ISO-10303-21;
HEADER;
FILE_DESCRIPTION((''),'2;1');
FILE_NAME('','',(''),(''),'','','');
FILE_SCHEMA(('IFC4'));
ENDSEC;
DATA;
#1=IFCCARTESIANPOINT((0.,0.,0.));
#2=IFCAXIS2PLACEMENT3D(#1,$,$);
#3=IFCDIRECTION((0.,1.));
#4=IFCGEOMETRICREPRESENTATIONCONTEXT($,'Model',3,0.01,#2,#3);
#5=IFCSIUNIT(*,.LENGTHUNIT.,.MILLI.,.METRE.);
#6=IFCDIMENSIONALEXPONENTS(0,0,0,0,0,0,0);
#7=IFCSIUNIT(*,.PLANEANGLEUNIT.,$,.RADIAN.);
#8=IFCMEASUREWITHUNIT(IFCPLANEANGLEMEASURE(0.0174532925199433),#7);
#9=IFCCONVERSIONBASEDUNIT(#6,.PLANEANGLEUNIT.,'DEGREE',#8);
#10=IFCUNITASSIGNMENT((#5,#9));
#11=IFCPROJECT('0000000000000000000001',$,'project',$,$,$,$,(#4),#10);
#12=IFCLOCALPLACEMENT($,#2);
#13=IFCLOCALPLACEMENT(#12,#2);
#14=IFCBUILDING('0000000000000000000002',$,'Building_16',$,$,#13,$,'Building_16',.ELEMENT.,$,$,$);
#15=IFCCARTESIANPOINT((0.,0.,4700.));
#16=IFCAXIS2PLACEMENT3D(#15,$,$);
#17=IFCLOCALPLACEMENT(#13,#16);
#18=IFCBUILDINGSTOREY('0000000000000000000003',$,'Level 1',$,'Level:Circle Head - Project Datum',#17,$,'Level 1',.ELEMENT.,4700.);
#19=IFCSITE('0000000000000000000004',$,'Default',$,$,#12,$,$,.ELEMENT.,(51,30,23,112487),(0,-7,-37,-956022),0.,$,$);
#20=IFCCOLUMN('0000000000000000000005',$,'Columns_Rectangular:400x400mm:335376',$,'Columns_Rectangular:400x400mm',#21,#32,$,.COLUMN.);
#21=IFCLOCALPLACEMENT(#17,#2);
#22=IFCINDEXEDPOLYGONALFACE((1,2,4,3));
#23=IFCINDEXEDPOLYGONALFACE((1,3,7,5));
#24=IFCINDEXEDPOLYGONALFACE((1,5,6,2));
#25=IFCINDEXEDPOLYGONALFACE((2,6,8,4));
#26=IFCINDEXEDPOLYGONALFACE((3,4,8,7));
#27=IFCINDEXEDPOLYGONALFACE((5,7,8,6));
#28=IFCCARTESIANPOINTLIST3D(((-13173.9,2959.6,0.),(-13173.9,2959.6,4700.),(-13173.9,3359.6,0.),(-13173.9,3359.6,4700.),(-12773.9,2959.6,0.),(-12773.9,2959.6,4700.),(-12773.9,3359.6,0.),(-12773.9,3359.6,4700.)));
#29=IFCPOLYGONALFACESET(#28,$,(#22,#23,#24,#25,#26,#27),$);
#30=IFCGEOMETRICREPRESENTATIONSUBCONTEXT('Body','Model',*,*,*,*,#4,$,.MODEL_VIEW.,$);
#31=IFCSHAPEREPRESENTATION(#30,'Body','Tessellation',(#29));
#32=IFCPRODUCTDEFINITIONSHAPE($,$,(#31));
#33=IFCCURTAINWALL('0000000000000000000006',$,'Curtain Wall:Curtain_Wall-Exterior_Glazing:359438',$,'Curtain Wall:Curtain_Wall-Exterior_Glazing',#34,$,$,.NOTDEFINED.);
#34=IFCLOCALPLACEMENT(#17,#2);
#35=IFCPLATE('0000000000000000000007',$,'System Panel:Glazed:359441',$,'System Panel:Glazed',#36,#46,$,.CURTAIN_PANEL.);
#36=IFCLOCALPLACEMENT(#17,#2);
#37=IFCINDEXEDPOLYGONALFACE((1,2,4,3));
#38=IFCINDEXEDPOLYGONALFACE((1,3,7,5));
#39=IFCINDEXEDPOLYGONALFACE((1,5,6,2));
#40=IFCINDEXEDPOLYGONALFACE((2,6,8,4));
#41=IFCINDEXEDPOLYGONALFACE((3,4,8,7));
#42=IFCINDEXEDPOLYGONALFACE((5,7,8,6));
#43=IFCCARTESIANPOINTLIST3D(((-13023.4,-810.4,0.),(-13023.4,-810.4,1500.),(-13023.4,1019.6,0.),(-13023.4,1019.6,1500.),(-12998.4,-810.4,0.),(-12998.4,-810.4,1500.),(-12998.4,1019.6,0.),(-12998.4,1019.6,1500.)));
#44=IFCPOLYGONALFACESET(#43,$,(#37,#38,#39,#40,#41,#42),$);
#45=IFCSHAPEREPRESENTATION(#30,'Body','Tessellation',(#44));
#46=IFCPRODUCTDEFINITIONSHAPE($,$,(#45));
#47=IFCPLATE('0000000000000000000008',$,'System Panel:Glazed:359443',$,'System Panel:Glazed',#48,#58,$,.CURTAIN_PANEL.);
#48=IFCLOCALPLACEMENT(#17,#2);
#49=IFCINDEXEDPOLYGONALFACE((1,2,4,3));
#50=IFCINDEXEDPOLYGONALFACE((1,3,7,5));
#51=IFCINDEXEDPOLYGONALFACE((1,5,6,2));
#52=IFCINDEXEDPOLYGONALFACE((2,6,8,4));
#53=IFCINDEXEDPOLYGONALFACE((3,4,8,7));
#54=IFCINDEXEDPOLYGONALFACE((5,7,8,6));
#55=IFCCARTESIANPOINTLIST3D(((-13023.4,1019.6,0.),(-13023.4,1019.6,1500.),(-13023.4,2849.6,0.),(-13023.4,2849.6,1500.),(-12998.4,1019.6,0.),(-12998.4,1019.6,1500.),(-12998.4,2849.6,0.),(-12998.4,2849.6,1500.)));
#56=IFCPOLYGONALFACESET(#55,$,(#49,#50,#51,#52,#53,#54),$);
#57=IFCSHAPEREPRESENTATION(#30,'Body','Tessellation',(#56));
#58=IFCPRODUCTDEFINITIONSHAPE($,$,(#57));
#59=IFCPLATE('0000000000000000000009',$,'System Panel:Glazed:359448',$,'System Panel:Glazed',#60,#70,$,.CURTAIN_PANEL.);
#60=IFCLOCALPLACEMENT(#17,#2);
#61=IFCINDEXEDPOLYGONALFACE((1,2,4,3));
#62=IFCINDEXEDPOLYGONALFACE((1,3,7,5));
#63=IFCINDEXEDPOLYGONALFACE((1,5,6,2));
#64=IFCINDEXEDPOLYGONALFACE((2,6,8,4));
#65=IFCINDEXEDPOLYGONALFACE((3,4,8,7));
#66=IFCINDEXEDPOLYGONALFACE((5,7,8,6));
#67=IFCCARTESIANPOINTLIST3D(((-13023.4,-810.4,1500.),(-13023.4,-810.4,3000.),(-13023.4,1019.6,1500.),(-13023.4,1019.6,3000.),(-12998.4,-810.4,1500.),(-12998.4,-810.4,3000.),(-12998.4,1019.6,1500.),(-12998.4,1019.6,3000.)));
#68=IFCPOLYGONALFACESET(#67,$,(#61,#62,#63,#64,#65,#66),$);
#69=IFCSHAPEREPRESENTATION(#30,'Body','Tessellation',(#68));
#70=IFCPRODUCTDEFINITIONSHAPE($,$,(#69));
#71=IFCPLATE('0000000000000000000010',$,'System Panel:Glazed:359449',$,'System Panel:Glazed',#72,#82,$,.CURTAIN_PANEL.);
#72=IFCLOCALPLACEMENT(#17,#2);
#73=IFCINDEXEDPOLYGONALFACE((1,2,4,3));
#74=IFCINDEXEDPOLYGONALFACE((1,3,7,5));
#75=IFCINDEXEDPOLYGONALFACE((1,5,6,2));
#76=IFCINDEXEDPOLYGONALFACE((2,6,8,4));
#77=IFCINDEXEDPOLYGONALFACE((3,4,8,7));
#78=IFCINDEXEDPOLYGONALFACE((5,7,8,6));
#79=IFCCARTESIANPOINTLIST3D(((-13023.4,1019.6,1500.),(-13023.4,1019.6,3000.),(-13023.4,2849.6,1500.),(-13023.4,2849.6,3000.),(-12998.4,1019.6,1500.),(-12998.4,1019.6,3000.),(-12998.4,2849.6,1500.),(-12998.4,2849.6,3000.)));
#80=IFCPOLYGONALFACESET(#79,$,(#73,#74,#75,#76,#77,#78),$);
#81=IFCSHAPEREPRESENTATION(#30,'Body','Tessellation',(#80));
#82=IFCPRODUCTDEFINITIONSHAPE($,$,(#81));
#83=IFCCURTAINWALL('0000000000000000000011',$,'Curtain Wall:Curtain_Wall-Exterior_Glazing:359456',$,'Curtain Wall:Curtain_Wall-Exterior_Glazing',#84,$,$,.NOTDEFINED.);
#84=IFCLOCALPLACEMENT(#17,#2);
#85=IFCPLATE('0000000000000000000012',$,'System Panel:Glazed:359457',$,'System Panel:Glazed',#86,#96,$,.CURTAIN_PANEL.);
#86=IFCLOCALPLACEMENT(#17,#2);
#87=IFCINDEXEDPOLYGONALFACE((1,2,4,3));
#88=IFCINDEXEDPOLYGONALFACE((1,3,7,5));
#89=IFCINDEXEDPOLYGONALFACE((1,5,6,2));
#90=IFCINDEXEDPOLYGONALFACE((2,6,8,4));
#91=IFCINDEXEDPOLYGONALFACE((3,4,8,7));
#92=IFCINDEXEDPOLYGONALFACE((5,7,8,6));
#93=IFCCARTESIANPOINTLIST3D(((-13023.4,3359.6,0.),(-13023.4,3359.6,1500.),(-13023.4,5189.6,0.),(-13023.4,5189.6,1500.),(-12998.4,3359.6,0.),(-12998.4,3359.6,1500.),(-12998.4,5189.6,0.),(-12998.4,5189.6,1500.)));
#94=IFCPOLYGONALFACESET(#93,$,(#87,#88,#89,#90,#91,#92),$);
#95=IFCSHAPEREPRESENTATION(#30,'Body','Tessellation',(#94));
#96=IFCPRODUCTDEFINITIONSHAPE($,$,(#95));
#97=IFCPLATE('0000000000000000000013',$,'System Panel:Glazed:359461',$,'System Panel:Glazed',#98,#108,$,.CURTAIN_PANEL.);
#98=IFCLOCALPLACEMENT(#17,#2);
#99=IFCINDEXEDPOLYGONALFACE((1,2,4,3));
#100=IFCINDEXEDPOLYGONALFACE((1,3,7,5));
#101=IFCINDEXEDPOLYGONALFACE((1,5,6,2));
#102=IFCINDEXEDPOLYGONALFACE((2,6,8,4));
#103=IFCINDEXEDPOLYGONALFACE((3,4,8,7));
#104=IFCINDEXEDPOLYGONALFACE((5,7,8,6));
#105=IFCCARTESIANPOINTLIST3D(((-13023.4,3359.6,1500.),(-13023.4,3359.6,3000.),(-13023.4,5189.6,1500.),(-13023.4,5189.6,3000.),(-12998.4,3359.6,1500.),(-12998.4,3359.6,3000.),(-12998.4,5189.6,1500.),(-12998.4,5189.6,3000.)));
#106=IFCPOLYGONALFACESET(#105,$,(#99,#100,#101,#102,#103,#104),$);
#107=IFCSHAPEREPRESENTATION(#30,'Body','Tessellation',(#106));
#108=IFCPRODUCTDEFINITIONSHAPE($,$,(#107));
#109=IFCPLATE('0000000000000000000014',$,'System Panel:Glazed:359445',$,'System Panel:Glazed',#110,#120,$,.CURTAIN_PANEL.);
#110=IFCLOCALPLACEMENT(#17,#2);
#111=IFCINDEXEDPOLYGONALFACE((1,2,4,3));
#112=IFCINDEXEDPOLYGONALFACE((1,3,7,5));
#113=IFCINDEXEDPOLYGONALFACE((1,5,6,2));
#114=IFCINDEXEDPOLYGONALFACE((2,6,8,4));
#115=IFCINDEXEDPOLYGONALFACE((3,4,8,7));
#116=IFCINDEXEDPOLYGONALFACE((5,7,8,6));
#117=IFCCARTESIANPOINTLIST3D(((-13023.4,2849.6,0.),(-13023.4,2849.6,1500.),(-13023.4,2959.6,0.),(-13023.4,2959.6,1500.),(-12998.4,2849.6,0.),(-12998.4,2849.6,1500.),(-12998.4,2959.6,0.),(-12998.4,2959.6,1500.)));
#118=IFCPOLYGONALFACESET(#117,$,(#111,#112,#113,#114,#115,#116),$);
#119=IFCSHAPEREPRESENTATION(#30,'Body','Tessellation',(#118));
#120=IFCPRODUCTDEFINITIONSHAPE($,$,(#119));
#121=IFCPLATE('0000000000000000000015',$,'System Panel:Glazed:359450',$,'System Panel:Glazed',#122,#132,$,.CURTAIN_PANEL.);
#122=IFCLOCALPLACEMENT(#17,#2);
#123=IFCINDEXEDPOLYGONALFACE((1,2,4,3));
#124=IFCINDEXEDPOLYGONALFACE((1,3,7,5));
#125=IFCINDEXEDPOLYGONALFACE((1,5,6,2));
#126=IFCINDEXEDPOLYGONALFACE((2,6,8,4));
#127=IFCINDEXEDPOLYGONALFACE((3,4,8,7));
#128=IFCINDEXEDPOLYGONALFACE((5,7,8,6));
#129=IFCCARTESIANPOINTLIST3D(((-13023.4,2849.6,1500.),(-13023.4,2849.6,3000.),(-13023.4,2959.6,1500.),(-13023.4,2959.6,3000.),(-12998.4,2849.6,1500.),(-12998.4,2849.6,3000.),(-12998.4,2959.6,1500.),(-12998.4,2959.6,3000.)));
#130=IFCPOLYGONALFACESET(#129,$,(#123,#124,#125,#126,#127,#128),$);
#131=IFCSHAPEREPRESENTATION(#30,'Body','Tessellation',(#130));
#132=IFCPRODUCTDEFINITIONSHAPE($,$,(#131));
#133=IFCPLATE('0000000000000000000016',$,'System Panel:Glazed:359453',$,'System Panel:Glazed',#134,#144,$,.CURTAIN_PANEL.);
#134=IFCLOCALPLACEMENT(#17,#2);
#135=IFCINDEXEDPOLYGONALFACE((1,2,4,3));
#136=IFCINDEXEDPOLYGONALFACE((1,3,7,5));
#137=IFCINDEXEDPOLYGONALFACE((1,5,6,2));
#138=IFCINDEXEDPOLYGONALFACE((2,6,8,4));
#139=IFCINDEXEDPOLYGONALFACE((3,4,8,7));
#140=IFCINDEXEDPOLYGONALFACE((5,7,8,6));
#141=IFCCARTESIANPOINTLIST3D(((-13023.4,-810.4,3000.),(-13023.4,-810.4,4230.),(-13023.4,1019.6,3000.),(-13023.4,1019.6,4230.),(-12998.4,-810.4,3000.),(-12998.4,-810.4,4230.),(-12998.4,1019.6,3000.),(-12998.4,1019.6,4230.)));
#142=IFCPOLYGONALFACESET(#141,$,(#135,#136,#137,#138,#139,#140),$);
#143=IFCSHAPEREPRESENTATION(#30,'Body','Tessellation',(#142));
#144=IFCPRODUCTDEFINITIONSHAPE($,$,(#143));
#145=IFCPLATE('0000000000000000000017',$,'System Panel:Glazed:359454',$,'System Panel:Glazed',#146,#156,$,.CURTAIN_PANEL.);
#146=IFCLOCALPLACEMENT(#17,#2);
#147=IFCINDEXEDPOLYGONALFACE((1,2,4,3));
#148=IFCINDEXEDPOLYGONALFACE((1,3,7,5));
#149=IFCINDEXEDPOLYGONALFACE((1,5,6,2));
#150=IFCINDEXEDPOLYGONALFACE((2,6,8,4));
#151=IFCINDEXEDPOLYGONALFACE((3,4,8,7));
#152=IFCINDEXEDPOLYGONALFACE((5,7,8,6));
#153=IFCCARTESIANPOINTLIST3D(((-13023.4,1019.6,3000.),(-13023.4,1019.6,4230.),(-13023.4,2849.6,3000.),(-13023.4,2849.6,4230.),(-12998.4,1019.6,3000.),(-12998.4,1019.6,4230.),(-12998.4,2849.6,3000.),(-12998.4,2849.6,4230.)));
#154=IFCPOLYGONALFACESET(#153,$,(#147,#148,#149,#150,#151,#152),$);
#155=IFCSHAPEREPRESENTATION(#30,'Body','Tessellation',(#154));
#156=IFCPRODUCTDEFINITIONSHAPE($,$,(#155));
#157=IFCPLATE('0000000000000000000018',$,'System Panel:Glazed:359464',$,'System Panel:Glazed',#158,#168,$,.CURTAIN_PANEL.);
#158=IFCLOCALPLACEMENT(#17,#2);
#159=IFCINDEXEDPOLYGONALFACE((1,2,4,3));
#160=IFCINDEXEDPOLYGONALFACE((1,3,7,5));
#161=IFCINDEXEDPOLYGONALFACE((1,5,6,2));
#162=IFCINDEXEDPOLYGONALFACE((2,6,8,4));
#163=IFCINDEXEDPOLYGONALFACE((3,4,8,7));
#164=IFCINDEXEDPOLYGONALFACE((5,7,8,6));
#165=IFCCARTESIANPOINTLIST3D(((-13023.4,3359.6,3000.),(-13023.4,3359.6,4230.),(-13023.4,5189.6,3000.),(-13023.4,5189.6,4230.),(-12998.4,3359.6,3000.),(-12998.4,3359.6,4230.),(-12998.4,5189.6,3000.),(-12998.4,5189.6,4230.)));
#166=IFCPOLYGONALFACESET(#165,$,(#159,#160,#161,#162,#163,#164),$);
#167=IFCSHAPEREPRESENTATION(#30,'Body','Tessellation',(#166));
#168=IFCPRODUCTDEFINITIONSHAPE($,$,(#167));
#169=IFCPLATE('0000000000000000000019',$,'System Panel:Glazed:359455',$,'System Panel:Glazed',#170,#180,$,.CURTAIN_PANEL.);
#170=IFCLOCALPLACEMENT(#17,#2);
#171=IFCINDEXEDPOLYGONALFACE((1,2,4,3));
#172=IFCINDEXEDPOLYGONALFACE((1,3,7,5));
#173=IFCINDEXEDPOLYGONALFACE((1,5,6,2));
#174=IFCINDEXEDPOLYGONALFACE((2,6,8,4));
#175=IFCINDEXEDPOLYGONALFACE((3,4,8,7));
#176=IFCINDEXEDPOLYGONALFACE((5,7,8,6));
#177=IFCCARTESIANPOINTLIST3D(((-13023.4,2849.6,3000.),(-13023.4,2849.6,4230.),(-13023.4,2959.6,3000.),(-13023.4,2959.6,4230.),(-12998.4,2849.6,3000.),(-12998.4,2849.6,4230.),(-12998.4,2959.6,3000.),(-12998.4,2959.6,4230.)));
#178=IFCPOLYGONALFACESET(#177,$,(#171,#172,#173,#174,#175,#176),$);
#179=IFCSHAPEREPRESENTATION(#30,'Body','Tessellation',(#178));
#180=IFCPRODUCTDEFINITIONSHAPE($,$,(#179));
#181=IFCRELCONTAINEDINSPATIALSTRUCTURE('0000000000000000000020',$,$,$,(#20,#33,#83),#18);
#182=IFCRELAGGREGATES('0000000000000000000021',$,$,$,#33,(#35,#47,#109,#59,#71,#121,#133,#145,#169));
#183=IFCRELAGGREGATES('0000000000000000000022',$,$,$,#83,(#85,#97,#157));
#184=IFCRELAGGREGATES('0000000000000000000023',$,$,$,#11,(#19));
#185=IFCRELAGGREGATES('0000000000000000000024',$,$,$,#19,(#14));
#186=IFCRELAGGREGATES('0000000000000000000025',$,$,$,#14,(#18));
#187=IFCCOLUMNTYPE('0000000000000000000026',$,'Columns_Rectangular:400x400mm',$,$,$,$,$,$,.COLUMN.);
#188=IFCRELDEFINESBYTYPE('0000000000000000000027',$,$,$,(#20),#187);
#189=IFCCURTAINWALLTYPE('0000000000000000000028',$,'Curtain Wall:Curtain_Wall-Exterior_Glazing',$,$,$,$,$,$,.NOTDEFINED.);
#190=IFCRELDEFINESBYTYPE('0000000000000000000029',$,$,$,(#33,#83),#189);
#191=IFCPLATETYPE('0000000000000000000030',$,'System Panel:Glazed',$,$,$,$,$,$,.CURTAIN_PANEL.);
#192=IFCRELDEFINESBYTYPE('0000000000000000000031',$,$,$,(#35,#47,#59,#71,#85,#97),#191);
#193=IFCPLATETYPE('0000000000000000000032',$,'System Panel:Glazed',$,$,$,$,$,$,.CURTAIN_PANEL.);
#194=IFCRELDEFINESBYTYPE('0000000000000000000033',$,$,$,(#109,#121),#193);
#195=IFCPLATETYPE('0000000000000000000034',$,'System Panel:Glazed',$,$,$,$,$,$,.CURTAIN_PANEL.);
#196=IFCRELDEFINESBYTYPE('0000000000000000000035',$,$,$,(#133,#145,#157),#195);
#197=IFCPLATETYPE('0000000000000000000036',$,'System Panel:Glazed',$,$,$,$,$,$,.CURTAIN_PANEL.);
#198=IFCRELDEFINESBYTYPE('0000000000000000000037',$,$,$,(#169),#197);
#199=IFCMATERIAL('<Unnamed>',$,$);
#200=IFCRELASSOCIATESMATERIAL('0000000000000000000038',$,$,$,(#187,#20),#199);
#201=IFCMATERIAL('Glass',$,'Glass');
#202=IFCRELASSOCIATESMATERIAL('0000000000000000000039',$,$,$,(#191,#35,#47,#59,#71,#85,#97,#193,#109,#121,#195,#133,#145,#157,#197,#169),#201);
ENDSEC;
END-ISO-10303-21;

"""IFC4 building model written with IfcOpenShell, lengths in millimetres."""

from ifc_helpers import new_model, entity, si_unit, converted_unit, direction, frame, origin, place, context, subcontext, project, spatial, indexed_curve, outline, extrude, source, transform, mapped, material, type_object, type_shapes, element, aggregate, save


model = new_model("IFC4")

# Units and contexts
model_context = context("Model", 3, precision=0.01, world=origin(), true_north=direction((0.0, 1.0)))
body_context = subcontext(model_context, "Body", "Model", "MODEL_VIEW")
ifc_project = project(units=[si_unit("LENGTHUNIT", "METRE", prefix="MILLI"), converted_unit("PLANEANGLEUNIT", "DEGREE", entity("IfcPlaneAngleMeasure", 0.0174532925199433), si_unit("PLANEANGLEUNIT", "RADIAN"), dimensions=[0, 0, 0, 0, 0, 0, 0])], contexts=[model_context])

# Site, building, storey
site_placement = place(None, origin())
site = spatial("IfcSite", under=ifc_project, at=site_placement, Name="Default", CompositionType="ELEMENT", RefLatitude=(51, 30, 23, 112487), RefLongitude=(0, -7, -37, -956022), RefElevation=0.0)
building_placement = place(site_placement, origin())
building = spatial("IfcBuilding", under=site, at=building_placement, Name="Building_16", LongName="Building_16", CompositionType="ELEMENT")
storey_placement = place(building_placement, frame((0.0, 0.0, 4700.0)))
storey = spatial("IfcBuildingStorey", under=building, at=storey_placement, Name="Level 1", ObjectType="Level:Circle Head - Project Datum", LongName="Level 1", CompositionType="ELEMENT", Elevation=4700.0)

# Column
ifc_material_1 = material(Name="<Unnamed>")
column_type_1 = type_object("IfcColumnType", Name="Columns_Rectangular:400x400mm", PredefinedType="COLUMN", material=ifc_material_1)
shared_shape_1 = source(origin(), body_context, "Body", "SweptSolid", [
    extrude(outline(indexed_curve([(-200.0, -200.0), (200.0, -200.0), (200.0, 200.0), (-200.0, 200.0), (-200.0, -200.0)], self_intersect=False)), frame((0.0, 0.0, 4700.0), z_axis=(0.0, 0.0, 1.0), x_axis=(-1.0, 0.0, 0.0)), (0.0, 0.0, 1.0), 4700.0),
])
type_shapes(column_type_1, [shared_shape_1])
column_1_placement = place(storey_placement, frame((-12973.9, 3159.6, -4700.0)))
element("IfcColumn", 1, at=column_1_placement, inside=storey, type_object=column_type_1, material=ifc_material_1, Name="Columns_Rectangular:400x400mm:335376", ObjectType="Columns_Rectangular:400x400mm", PredefinedType="COLUMN", context=body_context, shape_type="MappedRepresentation", body=[
    mapped(shared_shape_1, transform((0.0, 0.0, 0.0), scale=1.0)),
])

# Curtain walls, plates
curtain_wall_type = type_object("IfcCurtainWallType", Name="Curtain Wall:Curtain_Wall-Exterior_Glazing", PredefinedType="NOTDEFINED")
curtain_wall_1_placement = place(storey_placement, frame((0.0, 0.0, -4700.0)))
curtain_wall_1 = element("IfcCurtainWall", 2, at=curtain_wall_1_placement, inside=storey, type_object=curtain_wall_type, Name="Curtain Wall:Curtain_Wall-Exterior_Glazing:359438", ObjectType="Curtain Wall:Curtain_Wall-Exterior_Glazing", PredefinedType="NOTDEFINED")
ifc_material_2 = material(Name="Glass", Category="Glass")
plate_type_1 = type_object("IfcPlateType", Name="System Panel:Glazed", PredefinedType="CURTAIN_PANEL", material=ifc_material_2)
shared_shape_2 = source(origin(), body_context, "Body", "SweptSolid", [
    extrude(outline(indexed_curve([(-12.5, -915.0), (12.5, -915.0), (12.5, 915.0), (-12.5, 915.0), (-12.5, -915.0)], self_intersect=False)), frame((0.0, 37.0, 0.0), z_axis=(0.0, 0.0, 1.0), x_axis=(0.0, 1.0, 0.0)), (0.0, 0.0, 1.0), 1500.0),
])
type_shapes(plate_type_1, [shared_shape_2])
plate_1_placement = place(curtain_wall_1_placement, frame((-12973.9, 104.6, 4700.0), z_axis=(0.0, 0.0, 1.0), x_axis=(0.0, 1.0, 0.0)))
plate_1 = element("IfcPlate", 3, at=plate_1_placement, type_object=plate_type_1, material=ifc_material_2, Name="System Panel:Glazed:359441", ObjectType="System Panel:Glazed", PredefinedType="CURTAIN_PANEL", context=body_context, shape_type="MappedRepresentation", body=[
    mapped(shared_shape_2, transform((0.0, 0.0, 0.0), scale=1.0)),
])
plate_2_placement = place(curtain_wall_1_placement, frame((-12973.9, 1934.6, 4700.0), z_axis=(0.0, 0.0, 1.0), x_axis=(0.0, 1.0, 0.0)))
plate_2 = element("IfcPlate", 4, at=plate_2_placement, type_object=plate_type_1, material=ifc_material_2, Name="System Panel:Glazed:359443", ObjectType="System Panel:Glazed", PredefinedType="CURTAIN_PANEL", context=body_context, shape_type="MappedRepresentation", body=[
    mapped(shared_shape_2, transform((0.0, 0.0, 0.0), scale=1.0)),
])
plate_3_placement = place(curtain_wall_1_placement, frame((-12973.9, 104.6, 6200.0), z_axis=(0.0, 0.0, 1.0), x_axis=(0.0, 1.0, 0.0)))
plate_3 = element("IfcPlate", 5, at=plate_3_placement, type_object=plate_type_1, material=ifc_material_2, Name="System Panel:Glazed:359448", ObjectType="System Panel:Glazed", PredefinedType="CURTAIN_PANEL", context=body_context, shape_type="MappedRepresentation", body=[
    mapped(shared_shape_2, transform((0.0, 0.0, 0.0), scale=1.0)),
])
plate_4_placement = place(curtain_wall_1_placement, frame((-12973.9, 1934.6, 6200.0), z_axis=(0.0, 0.0, 1.0), x_axis=(0.0, 1.0, 0.0)))
plate_4 = element("IfcPlate", 6, at=plate_4_placement, type_object=plate_type_1, material=ifc_material_2, Name="System Panel:Glazed:359449", ObjectType="System Panel:Glazed", PredefinedType="CURTAIN_PANEL", context=body_context, shape_type="MappedRepresentation", body=[
    mapped(shared_shape_2, transform((0.0, 0.0, 0.0), scale=1.0)),
])
curtain_wall_2_placement = place(storey_placement, frame((0.0, 0.0, -4700.0)))
curtain_wall_2 = element("IfcCurtainWall", 7, at=curtain_wall_2_placement, inside=storey, type_object=curtain_wall_type, Name="Curtain Wall:Curtain_Wall-Exterior_Glazing:359456", ObjectType="Curtain Wall:Curtain_Wall-Exterior_Glazing", PredefinedType="NOTDEFINED")
plate_5_placement = place(curtain_wall_2_placement, frame((-12973.9, 4274.6, 4700.0), z_axis=(0.0, 0.0, 1.0), x_axis=(0.0, 1.0, 0.0)))
plate_5 = element("IfcPlate", 8, at=plate_5_placement, type_object=plate_type_1, material=ifc_material_2, Name="System Panel:Glazed:359457", ObjectType="System Panel:Glazed", PredefinedType="CURTAIN_PANEL", context=body_context, shape_type="MappedRepresentation", body=[
    mapped(shared_shape_2, transform((0.0, 0.0, 0.0), scale=1.0)),
])
plate_6_placement = place(curtain_wall_2_placement, frame((-12973.9, 4274.6, 6200.0), z_axis=(0.0, 0.0, 1.0), x_axis=(0.0, 1.0, 0.0)))
plate_6 = element("IfcPlate", 9, at=plate_6_placement, type_object=plate_type_1, material=ifc_material_2, Name="System Panel:Glazed:359461", ObjectType="System Panel:Glazed", PredefinedType="CURTAIN_PANEL", context=body_context, shape_type="MappedRepresentation", body=[
    mapped(shared_shape_2, transform((0.0, 0.0, 0.0), scale=1.0)),
])

# Plates
plate_type_2 = type_object("IfcPlateType", Name="System Panel:Glazed", PredefinedType="CURTAIN_PANEL", material=ifc_material_2)
shared_shape_3 = source(origin(), body_context, "Body", "SweptSolid", [
    extrude(outline(indexed_curve([(-12.5, -55.0), (12.5, -55.0), (12.5, 55.0), (-12.5, 55.0), (-12.5, -55.0)], self_intersect=False)), frame((0.0, 37.0, 0.0), z_axis=(0.0, 0.0, 1.0), x_axis=(0.0, 1.0, 0.0)), (0.0, 0.0, 1.0), 1500.0),
])
type_shapes(plate_type_2, [shared_shape_3])
plate_7_placement = place(curtain_wall_1_placement, frame((-12973.9, 2904.6, 4700.0), z_axis=(0.0, 0.0, 1.0), x_axis=(0.0, 1.0, 0.0)))
plate_7 = element("IfcPlate", 10, at=plate_7_placement, type_object=plate_type_2, material=ifc_material_2, Name="System Panel:Glazed:359445", ObjectType="System Panel:Glazed", PredefinedType="CURTAIN_PANEL", context=body_context, shape_type="MappedRepresentation", body=[
    mapped(shared_shape_3, transform((0.0, 0.0, 0.0), scale=1.0)),
])
plate_8_placement = place(curtain_wall_1_placement, frame((-12973.9, 2904.6, 6200.0), z_axis=(0.0, 0.0, 1.0), x_axis=(0.0, 1.0, 0.0)))
plate_8 = element("IfcPlate", 11, at=plate_8_placement, type_object=plate_type_2, material=ifc_material_2, Name="System Panel:Glazed:359450", ObjectType="System Panel:Glazed", PredefinedType="CURTAIN_PANEL", context=body_context, shape_type="MappedRepresentation", body=[
    mapped(shared_shape_3, transform((0.0, 0.0, 0.0), scale=1.0)),
])
plate_type_3 = type_object("IfcPlateType", Name="System Panel:Glazed", PredefinedType="CURTAIN_PANEL", material=ifc_material_2)
shared_shape_4 = source(origin(), body_context, "Body", "SweptSolid", [
    extrude(outline(indexed_curve([(-12.5, -915.0), (12.5, -915.0), (12.5, 915.0), (-12.5, 915.0), (-12.5, -915.0)], self_intersect=False)), frame((0.0, 37.0, 0.0), z_axis=(0.0, 0.0, 1.0), x_axis=(0.0, 1.0, 0.0)), (0.0, 0.0, 1.0), 1230.0),
])
type_shapes(plate_type_3, [shared_shape_4])
plate_9_placement = place(curtain_wall_1_placement, frame((-12973.9, 104.6, 7700.0), z_axis=(0.0, 0.0, 1.0), x_axis=(0.0, 1.0, 0.0)))
plate_9 = element("IfcPlate", 12, at=plate_9_placement, type_object=plate_type_3, material=ifc_material_2, Name="System Panel:Glazed:359453", ObjectType="System Panel:Glazed", PredefinedType="CURTAIN_PANEL", context=body_context, shape_type="MappedRepresentation", body=[
    mapped(shared_shape_4, transform((0.0, 0.0, 0.0), scale=1.0)),
])
plate_10_placement = place(curtain_wall_1_placement, frame((-12973.9, 1934.6, 7700.0), z_axis=(0.0, 0.0, 1.0), x_axis=(0.0, 1.0, 0.0)))
plate_10 = element("IfcPlate", 13, at=plate_10_placement, type_object=plate_type_3, material=ifc_material_2, Name="System Panel:Glazed:359454", ObjectType="System Panel:Glazed", PredefinedType="CURTAIN_PANEL", context=body_context, shape_type="MappedRepresentation", body=[
    mapped(shared_shape_4, transform((0.0, 0.0, 0.0), scale=1.0)),
])
plate_11_placement = place(curtain_wall_2_placement, frame((-12973.9, 4274.6, 7700.0), z_axis=(0.0, 0.0, 1.0), x_axis=(0.0, 1.0, 0.0)))
plate_11 = element("IfcPlate", 14, at=plate_11_placement, type_object=plate_type_3, material=ifc_material_2, Name="System Panel:Glazed:359464", ObjectType="System Panel:Glazed", PredefinedType="CURTAIN_PANEL", context=body_context, shape_type="MappedRepresentation", body=[
    mapped(shared_shape_4, transform((0.0, 0.0, 0.0), scale=1.0)),
])
plate_type_4 = type_object("IfcPlateType", Name="System Panel:Glazed", PredefinedType="CURTAIN_PANEL", material=ifc_material_2)
shared_shape_5 = source(origin(), body_context, "Body", "SweptSolid", [
    extrude(outline(indexed_curve([(-12.5, -55.0), (12.5, -55.0), (12.5, 55.0), (-12.5, 55.0), (-12.5, -55.0)], self_intersect=False)), frame((0.0, 37.0, 0.0), z_axis=(0.0, 0.0, 1.0), x_axis=(0.0, 1.0, 0.0)), (0.0, 0.0, 1.0), 1230.0),
])
type_shapes(plate_type_4, [shared_shape_5])
plate_12_placement = place(curtain_wall_1_placement, frame((-12973.9, 2904.6, 7700.0), z_axis=(0.0, 0.0, 1.0), x_axis=(0.0, 1.0, 0.0)))
plate_12 = element("IfcPlate", 15, at=plate_12_placement, type_object=plate_type_4, material=ifc_material_2, Name="System Panel:Glazed:359455", ObjectType="System Panel:Glazed", PredefinedType="CURTAIN_PANEL", context=body_context, shape_type="MappedRepresentation", body=[
    mapped(shared_shape_5, transform((0.0, 0.0, 0.0), scale=1.0)),
])
aggregate(curtain_wall_1, [plate_1, plate_2, plate_7, plate_3, plate_4, plate_8, plate_9, plate_10, plate_12])

aggregate(curtain_wall_2, [plate_5, plate_6, plate_11])

save(model, "model.ifc")
